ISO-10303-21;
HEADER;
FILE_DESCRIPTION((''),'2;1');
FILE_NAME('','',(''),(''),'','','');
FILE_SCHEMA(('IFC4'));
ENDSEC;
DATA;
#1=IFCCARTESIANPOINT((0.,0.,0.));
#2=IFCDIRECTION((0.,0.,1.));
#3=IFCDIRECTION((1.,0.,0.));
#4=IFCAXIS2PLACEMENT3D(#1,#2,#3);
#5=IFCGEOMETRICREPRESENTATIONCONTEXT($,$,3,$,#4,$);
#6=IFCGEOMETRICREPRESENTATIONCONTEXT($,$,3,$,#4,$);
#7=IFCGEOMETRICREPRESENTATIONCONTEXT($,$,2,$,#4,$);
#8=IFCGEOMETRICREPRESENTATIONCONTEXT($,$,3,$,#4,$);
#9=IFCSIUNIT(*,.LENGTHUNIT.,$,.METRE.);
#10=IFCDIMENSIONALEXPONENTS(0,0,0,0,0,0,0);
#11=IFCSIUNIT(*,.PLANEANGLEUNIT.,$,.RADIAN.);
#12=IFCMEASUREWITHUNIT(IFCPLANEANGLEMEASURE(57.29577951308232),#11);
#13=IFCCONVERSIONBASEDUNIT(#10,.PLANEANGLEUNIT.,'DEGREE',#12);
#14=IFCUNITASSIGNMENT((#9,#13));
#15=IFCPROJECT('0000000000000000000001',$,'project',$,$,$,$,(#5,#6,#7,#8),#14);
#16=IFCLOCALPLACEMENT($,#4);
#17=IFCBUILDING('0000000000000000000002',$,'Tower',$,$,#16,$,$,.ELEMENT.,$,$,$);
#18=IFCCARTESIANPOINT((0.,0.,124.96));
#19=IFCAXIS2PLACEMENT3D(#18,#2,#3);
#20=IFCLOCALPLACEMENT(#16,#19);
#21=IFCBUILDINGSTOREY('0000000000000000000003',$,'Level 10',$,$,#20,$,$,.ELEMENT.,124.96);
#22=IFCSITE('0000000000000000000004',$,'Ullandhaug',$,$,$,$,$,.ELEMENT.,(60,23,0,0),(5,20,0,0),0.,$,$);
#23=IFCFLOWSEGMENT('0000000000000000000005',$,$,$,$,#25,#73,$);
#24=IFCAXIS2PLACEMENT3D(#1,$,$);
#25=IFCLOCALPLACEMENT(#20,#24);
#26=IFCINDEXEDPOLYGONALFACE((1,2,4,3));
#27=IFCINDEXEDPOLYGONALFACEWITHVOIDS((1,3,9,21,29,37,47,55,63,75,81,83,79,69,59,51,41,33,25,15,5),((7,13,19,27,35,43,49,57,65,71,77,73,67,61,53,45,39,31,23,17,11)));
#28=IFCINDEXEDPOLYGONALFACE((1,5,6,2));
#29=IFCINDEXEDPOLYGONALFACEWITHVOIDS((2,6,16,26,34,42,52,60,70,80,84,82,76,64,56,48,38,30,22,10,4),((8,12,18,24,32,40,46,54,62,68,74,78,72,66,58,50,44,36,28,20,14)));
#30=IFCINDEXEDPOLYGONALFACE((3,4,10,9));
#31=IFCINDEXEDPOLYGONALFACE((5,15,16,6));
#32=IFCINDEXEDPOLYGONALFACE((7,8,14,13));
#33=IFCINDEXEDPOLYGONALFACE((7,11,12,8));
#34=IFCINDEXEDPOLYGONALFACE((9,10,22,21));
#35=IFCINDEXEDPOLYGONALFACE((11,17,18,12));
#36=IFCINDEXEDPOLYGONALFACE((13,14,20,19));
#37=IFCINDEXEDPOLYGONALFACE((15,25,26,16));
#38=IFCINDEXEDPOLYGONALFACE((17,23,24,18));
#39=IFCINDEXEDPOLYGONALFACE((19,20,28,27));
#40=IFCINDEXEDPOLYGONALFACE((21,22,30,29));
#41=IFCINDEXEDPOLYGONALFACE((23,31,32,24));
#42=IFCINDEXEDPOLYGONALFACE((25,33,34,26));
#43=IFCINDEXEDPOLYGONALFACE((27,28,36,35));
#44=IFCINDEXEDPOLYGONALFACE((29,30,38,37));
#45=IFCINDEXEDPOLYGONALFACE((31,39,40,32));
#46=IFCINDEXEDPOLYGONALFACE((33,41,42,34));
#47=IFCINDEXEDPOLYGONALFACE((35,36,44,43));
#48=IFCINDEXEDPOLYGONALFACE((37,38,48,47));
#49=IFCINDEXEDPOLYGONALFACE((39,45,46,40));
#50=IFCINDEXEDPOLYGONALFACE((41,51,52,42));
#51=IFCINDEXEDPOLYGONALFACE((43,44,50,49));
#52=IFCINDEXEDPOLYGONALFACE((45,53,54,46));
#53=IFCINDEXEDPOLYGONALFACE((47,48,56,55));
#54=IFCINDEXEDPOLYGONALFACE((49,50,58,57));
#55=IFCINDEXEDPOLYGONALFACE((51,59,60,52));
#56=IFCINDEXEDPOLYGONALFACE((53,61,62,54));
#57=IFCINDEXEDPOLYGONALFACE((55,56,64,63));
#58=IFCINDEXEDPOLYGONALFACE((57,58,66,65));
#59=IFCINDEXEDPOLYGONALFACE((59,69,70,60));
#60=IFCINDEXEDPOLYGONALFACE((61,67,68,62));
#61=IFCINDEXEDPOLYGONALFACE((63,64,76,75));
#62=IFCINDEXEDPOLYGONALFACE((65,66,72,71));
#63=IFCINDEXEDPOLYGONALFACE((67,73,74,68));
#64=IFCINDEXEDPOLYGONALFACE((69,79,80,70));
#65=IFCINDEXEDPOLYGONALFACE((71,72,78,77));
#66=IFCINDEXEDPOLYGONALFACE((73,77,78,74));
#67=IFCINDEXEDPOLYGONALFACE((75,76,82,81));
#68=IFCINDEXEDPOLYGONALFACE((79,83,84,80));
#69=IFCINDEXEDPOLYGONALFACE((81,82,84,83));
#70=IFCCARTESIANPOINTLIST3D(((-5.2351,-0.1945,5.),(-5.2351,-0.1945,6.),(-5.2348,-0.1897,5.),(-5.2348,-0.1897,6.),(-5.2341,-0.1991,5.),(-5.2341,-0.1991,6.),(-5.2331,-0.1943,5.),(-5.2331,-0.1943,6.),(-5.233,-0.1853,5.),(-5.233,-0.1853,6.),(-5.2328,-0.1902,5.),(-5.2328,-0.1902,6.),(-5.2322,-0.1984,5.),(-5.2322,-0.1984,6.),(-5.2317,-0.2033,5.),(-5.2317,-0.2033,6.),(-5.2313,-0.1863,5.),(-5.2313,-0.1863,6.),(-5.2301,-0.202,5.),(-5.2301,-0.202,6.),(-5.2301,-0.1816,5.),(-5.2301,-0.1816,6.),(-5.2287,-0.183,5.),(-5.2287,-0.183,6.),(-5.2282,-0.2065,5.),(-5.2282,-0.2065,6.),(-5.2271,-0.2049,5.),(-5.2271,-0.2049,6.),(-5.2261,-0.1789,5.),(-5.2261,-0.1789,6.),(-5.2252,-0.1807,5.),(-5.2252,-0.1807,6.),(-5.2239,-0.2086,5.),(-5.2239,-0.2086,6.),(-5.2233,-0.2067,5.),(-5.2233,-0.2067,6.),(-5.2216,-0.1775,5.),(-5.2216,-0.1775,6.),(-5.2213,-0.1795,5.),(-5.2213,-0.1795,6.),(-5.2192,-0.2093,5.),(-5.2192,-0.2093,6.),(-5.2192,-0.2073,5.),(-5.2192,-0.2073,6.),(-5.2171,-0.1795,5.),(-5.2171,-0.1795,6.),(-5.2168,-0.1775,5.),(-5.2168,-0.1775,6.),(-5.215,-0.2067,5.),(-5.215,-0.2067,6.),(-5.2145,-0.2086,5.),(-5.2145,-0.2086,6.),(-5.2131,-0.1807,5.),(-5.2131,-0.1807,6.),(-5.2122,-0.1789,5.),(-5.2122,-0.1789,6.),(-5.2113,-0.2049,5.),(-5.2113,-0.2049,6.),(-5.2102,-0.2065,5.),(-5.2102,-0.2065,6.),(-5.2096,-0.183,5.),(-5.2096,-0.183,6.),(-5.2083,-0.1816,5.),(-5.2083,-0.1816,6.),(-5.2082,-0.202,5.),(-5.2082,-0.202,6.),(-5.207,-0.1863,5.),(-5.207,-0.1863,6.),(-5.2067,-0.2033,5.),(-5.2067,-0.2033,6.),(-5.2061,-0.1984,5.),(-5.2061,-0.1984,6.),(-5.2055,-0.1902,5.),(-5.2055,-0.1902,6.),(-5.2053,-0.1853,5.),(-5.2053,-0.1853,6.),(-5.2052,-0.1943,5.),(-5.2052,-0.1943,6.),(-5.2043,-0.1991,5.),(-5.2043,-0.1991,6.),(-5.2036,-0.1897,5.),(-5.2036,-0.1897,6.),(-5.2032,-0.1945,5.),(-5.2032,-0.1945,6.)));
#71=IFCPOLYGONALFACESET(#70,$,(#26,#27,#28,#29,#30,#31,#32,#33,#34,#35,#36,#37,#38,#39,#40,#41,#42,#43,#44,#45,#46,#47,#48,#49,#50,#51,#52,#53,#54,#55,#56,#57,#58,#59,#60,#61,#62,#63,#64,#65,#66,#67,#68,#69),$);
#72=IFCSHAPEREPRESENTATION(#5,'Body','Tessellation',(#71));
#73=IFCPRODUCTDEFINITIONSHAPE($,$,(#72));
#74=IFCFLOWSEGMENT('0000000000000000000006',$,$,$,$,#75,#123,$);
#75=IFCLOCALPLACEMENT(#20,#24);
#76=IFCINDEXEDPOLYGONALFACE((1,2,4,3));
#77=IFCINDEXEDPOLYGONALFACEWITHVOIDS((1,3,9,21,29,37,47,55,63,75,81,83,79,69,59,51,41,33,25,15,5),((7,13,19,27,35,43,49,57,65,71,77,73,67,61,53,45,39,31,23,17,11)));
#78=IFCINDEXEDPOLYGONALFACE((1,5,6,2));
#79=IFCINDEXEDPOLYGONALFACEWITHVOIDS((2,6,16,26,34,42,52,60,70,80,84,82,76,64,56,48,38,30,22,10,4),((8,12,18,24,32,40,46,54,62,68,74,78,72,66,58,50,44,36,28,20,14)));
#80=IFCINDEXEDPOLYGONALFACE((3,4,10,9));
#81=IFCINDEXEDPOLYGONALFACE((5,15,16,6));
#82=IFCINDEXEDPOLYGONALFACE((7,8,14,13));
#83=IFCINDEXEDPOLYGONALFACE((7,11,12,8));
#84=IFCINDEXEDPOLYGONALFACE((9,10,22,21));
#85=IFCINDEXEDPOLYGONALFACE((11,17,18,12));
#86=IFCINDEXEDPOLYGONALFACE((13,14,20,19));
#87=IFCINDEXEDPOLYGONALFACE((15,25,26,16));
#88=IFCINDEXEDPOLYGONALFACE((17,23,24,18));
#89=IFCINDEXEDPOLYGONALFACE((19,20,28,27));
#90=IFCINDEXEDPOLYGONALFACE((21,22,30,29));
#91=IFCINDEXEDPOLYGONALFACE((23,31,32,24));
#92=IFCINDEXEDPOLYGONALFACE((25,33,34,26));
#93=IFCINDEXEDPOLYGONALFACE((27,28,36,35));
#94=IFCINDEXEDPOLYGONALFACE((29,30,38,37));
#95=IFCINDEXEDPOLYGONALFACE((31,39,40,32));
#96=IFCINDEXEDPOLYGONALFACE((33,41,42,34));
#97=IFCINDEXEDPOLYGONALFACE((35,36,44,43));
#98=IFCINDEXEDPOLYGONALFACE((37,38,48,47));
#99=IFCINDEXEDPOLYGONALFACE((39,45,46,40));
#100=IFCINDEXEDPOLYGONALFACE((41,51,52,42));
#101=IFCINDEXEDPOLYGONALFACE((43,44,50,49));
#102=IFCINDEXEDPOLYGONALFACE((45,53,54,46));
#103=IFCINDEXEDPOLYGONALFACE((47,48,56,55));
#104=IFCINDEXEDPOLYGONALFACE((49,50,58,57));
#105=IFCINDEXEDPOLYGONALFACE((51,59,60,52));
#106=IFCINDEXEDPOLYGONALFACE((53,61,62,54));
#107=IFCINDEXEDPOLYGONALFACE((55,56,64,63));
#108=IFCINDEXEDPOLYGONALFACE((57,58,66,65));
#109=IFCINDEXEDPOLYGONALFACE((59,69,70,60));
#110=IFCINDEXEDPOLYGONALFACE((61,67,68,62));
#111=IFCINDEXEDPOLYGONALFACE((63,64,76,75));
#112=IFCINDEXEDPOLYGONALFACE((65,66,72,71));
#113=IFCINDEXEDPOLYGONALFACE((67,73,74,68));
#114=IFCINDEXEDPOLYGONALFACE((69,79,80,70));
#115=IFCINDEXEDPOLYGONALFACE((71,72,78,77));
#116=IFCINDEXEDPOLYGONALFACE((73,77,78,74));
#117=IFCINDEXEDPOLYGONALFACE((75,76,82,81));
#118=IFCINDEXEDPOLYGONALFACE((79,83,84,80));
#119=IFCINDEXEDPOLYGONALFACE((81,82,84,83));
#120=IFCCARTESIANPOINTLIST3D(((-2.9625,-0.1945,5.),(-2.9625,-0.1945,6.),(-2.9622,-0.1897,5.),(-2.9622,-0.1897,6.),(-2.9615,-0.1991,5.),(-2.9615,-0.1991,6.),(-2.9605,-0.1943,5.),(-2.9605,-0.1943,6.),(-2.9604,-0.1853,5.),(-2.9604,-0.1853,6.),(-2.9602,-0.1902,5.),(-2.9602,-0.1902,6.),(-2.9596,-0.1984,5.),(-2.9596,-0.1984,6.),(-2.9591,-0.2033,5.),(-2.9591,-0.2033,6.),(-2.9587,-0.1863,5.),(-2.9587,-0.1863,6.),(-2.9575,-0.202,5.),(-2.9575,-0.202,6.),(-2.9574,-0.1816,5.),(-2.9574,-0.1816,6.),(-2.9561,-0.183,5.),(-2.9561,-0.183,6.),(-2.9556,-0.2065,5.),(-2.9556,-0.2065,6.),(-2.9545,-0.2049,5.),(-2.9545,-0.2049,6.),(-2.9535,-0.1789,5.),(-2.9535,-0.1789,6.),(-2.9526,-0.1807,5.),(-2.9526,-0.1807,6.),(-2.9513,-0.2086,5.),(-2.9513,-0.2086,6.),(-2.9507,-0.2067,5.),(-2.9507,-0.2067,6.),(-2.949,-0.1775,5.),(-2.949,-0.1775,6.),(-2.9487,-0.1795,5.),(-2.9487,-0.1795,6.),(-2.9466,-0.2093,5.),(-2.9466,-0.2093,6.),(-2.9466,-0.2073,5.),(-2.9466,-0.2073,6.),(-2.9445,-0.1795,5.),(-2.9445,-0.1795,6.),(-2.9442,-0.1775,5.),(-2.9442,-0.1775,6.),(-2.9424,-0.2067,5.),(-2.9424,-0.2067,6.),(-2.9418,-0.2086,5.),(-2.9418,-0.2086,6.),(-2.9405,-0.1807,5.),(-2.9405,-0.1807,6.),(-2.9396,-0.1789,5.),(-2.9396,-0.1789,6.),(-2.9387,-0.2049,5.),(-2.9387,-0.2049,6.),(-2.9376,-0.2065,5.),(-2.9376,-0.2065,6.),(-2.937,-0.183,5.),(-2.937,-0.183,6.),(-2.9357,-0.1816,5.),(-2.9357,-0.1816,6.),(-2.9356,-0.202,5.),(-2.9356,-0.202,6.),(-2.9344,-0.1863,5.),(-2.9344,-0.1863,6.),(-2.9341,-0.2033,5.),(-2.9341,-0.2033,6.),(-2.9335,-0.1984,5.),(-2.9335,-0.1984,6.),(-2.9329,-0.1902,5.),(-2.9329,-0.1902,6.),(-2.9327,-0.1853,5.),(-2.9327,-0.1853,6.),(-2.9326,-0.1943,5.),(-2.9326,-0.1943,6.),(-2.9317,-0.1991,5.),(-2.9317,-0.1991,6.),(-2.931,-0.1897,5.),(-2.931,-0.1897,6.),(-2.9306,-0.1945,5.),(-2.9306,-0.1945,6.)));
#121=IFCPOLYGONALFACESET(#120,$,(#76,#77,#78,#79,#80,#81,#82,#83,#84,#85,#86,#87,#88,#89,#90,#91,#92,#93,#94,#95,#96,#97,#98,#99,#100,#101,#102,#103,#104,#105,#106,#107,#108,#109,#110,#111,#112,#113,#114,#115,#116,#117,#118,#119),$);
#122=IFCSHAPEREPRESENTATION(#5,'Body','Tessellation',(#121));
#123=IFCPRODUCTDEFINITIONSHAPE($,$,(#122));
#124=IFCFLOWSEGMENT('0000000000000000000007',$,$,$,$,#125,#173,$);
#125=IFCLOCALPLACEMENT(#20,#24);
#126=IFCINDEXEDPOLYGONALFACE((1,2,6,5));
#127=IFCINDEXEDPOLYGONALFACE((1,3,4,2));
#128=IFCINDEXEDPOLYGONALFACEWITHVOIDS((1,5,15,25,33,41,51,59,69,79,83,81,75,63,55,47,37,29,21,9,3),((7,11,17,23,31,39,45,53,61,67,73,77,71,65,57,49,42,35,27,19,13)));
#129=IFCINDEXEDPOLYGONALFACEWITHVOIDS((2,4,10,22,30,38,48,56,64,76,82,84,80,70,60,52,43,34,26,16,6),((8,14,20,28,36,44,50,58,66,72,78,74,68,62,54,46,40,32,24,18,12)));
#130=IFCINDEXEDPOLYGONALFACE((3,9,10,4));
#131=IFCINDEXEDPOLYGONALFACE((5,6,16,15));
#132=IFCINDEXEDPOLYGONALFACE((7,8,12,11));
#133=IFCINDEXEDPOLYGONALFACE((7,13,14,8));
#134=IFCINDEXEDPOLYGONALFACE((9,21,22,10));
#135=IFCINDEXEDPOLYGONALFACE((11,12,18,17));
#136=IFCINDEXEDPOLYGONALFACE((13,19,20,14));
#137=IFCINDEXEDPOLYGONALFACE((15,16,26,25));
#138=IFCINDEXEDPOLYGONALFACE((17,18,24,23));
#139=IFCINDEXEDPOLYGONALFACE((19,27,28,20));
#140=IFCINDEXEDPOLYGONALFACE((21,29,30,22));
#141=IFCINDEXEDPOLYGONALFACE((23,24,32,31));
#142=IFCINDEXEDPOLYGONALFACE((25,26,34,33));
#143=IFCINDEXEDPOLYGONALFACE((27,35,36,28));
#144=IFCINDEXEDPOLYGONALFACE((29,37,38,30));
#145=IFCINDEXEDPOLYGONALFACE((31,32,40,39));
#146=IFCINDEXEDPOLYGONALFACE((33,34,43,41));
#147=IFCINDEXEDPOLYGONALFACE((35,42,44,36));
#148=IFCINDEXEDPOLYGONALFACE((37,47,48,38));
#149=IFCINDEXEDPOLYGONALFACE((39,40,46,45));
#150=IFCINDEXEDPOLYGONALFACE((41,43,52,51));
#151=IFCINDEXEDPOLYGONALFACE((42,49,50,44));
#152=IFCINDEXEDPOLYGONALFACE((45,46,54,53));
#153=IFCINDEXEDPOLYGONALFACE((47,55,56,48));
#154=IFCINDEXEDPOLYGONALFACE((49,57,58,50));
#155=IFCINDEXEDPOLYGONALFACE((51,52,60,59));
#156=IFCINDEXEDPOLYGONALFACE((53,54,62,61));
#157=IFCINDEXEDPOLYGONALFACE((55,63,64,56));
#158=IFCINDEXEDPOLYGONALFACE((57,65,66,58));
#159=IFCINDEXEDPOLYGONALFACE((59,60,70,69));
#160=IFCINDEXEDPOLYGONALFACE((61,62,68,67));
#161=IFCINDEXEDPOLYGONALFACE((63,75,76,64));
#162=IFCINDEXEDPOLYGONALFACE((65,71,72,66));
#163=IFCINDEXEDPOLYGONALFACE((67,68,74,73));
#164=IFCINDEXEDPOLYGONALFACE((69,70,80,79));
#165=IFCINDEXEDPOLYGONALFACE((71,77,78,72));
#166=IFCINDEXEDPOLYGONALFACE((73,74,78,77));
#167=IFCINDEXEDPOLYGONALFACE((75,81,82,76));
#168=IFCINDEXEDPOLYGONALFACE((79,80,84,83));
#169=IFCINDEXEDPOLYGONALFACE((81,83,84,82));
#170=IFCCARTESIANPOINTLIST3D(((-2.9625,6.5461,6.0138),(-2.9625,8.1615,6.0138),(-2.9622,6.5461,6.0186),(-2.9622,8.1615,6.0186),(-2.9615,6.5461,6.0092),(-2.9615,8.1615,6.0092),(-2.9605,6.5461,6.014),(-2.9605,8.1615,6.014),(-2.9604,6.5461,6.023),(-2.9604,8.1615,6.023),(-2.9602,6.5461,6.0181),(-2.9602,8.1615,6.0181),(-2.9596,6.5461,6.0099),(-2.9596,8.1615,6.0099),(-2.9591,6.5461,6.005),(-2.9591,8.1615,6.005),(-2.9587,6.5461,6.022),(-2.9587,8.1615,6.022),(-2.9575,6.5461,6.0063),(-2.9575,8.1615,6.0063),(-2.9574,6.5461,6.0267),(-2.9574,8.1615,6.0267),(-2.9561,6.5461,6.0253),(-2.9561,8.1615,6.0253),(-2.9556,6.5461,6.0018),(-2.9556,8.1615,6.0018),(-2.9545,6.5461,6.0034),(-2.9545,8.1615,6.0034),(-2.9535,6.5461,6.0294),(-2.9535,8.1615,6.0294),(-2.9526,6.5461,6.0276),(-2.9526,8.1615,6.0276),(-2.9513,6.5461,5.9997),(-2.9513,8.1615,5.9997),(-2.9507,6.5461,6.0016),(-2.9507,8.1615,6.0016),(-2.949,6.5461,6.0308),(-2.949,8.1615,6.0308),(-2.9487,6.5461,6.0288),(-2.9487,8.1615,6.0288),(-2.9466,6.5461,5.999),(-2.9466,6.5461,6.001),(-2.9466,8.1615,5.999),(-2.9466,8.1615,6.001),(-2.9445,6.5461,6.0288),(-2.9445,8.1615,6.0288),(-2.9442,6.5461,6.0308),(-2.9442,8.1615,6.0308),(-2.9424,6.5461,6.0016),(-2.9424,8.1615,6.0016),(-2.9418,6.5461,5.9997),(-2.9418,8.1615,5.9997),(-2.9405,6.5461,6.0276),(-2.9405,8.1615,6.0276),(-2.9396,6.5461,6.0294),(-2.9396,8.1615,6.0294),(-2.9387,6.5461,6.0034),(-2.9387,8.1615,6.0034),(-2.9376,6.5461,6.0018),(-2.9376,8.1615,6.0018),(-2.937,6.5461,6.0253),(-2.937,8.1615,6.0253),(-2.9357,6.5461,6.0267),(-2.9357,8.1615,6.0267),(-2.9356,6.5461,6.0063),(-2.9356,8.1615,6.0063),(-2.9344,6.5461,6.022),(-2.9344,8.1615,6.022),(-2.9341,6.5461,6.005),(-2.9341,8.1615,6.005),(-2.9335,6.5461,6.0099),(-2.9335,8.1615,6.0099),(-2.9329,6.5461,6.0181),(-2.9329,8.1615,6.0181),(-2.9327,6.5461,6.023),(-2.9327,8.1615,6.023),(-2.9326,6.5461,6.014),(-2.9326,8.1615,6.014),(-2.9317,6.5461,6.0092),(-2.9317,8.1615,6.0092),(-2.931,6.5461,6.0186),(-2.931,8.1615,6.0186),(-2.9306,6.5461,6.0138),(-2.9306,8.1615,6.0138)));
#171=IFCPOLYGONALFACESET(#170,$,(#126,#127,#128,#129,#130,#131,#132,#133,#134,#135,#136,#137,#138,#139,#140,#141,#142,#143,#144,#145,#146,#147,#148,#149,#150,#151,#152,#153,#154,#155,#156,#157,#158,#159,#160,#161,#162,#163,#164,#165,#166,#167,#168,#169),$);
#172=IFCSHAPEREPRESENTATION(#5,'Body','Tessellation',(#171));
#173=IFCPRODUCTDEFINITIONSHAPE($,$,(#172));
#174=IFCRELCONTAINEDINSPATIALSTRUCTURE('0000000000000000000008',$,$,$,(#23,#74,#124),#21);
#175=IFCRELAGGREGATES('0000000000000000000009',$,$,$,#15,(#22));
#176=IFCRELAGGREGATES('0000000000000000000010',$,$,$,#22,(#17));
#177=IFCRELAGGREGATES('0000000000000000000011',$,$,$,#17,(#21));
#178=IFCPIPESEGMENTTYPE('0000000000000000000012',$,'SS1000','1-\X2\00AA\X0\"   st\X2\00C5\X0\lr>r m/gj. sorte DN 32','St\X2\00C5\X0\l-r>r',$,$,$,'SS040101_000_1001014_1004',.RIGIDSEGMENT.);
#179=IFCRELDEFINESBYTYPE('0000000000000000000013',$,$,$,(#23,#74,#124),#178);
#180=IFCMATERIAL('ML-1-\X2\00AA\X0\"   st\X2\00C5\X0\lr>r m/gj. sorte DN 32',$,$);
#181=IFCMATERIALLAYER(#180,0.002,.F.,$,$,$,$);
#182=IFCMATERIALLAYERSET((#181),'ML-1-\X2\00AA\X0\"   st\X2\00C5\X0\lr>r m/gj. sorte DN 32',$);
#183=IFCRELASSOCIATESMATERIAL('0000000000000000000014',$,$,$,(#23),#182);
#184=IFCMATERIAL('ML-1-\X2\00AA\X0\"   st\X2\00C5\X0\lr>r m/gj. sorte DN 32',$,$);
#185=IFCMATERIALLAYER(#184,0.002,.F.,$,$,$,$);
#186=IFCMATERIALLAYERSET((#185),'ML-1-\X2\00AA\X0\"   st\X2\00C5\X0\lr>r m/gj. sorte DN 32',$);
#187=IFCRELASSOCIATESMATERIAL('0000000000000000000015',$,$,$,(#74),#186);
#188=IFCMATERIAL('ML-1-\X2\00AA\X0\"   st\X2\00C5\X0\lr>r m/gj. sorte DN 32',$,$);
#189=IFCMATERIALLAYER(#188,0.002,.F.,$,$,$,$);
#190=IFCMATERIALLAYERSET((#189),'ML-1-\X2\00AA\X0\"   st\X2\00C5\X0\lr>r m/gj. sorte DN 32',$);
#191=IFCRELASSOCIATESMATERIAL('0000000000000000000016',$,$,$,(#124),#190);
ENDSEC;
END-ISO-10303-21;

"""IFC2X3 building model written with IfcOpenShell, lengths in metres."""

from ifc_helpers import new_model, entity, si_unit, converted_unit, frame, origin_with_axes, origin_2d_with_axis, place, context, project, spatial, hollow_circle, extrude, material, layer, layer_set, layer_usage, type_object, element, save


model = new_model("IFC2X3")

# Units and contexts
context_of_model_1 = context(None, 3, world=origin_with_axes())
context_of_model_2 = context(None, 3, world=origin_with_axes())
context_of_model_3 = context(None, 2, world=origin_with_axes())
context_of_model_4 = context(None, 3, world=origin_with_axes())
ifc_project = project(units=[si_unit("LENGTHUNIT", "METRE"), converted_unit("PLANEANGLEUNIT", "DEGREE", entity("IfcPlaneAngleMeasure", 57.29577951308232), si_unit("PLANEANGLEUNIT", "RADIAN"), dimensions=[0, 0, 0, 0, 0, 0, 0])], contexts=[context_of_model_1, context_of_model_2, context_of_model_3, context_of_model_4])

# Site, building, storey
site = spatial("IfcSite", under=ifc_project, Name="Ullandhaug", CompositionType="ELEMENT", RefLatitude=(60, 23, 0, 0), RefLongitude=(5, 20, 0, 0), RefElevation=0.0)
building_placement = place(None, origin_with_axes())
building = spatial("IfcBuilding", under=site, at=building_placement, Name="Tower", CompositionType="ELEMENT")
storey_placement = place(building_placement, frame((0.0, 0.0, 124.96), z_axis=(0.0, 0.0, 1.0), x_axis=(1.0, 0.0, 0.0)))
storey = spatial("IfcBuildingStorey", under=building, at=storey_placement, Name="Level 10", CompositionType="ELEMENT", Elevation=124.96)

# Flow segments
pipe_segment_type_1 = type_object("IfcPipeSegmentType", Name="SS1000", Description="1-ª\"   stÅlr>r m/gj. sorte DN 32", ApplicableOccurrence="StÅl-r>r", ElementType="SS040101_000_1001014_1004", PredefinedType="RIGIDSEGMENT")
ifc_material_1 = material(Name="ML-1-ª\"   stÅlr>r m/gj. sorte DN 32")
ifc_layer_1 = layer(ifc_material_1, 0.002, ventilated=False)
ifc_layer_set_1 = layer_set([ifc_layer_1], Name="ML-1-ª\"   stÅlr>r m/gj. sorte DN 32")
ifc_layer_usage_1 = layer_usage(ifc_layer_set_1, "AXIS2", "POSITIVE", 0.0)
flow_segment_1_placement = place(storey_placement, frame((-5.2192, -0.1933, 5.0), z_axis=(0.0, 0.0, 1.0), x_axis=(0.0, -1.0, 0.0)))
element("IfcFlowSegment", 1, at=flow_segment_1_placement, inside=storey, type_object=pipe_segment_type_1, material=ifc_layer_usage_1, context=context_of_model_1, shape_type="SweptSolid", body=[
    extrude(hollow_circle(Radius=0.016, WallThickness=0.002, at=origin_2d_with_axis()), origin_with_axes(), (0.0, 0.0, 1.0), 1.0),
])
ifc_material_2 = material(Name="ML-1-ª\"   stÅlr>r m/gj. sorte DN 32")
ifc_layer_2 = layer(ifc_material_2, 0.002, ventilated=False)
ifc_layer_set_2 = layer_set([ifc_layer_2], Name="ML-1-ª\"   stÅlr>r m/gj. sorte DN 32")
ifc_layer_usage_2 = layer_usage(ifc_layer_set_2, "AXIS2", "POSITIVE", 0.0)
flow_segment_2_placement = place(storey_placement, frame((-2.9466, -0.1933, 5.0), z_axis=(0.0, 0.0, 1.0), x_axis=(0.0, -1.0, 0.0)))
element("IfcFlowSegment", 2, at=flow_segment_2_placement, inside=storey, type_object=pipe_segment_type_1, material=ifc_layer_usage_2, context=context_of_model_1, shape_type="SweptSolid", body=[
    extrude(hollow_circle(Radius=0.016, WallThickness=0.002, at=origin_2d_with_axis()), origin_with_axes(), (0.0, 0.0, 1.0), 1.0),
])
ifc_material_3 = material(Name="ML-1-ª\"   stÅlr>r m/gj. sorte DN 32")
ifc_layer_3 = layer(ifc_material_3, 0.002, ventilated=False)
ifc_layer_set_3 = layer_set([ifc_layer_3], Name="ML-1-ª\"   stÅlr>r m/gj. sorte DN 32")
ifc_layer_usage_3 = layer_usage(ifc_layer_set_3, "AXIS2", "POSITIVE", 0.0)
flow_segment_3_placement = place(storey_placement, frame((-2.9466, 6.5461, 6.015), z_axis=(0.0, 1.0, 0.0), x_axis=(0.0, 0.0, -1.0)))
element("IfcFlowSegment", 3, at=flow_segment_3_placement, inside=storey, type_object=pipe_segment_type_1, material=ifc_layer_usage_3, context=context_of_model_1, shape_type="SweptSolid", body=[
    extrude(hollow_circle(Radius=0.016, WallThickness=0.002, at=origin_2d_with_axis()), origin_with_axes(), (0.0, 0.0, 1.0), 1.6154),
])

save(model, "model.ifc")
